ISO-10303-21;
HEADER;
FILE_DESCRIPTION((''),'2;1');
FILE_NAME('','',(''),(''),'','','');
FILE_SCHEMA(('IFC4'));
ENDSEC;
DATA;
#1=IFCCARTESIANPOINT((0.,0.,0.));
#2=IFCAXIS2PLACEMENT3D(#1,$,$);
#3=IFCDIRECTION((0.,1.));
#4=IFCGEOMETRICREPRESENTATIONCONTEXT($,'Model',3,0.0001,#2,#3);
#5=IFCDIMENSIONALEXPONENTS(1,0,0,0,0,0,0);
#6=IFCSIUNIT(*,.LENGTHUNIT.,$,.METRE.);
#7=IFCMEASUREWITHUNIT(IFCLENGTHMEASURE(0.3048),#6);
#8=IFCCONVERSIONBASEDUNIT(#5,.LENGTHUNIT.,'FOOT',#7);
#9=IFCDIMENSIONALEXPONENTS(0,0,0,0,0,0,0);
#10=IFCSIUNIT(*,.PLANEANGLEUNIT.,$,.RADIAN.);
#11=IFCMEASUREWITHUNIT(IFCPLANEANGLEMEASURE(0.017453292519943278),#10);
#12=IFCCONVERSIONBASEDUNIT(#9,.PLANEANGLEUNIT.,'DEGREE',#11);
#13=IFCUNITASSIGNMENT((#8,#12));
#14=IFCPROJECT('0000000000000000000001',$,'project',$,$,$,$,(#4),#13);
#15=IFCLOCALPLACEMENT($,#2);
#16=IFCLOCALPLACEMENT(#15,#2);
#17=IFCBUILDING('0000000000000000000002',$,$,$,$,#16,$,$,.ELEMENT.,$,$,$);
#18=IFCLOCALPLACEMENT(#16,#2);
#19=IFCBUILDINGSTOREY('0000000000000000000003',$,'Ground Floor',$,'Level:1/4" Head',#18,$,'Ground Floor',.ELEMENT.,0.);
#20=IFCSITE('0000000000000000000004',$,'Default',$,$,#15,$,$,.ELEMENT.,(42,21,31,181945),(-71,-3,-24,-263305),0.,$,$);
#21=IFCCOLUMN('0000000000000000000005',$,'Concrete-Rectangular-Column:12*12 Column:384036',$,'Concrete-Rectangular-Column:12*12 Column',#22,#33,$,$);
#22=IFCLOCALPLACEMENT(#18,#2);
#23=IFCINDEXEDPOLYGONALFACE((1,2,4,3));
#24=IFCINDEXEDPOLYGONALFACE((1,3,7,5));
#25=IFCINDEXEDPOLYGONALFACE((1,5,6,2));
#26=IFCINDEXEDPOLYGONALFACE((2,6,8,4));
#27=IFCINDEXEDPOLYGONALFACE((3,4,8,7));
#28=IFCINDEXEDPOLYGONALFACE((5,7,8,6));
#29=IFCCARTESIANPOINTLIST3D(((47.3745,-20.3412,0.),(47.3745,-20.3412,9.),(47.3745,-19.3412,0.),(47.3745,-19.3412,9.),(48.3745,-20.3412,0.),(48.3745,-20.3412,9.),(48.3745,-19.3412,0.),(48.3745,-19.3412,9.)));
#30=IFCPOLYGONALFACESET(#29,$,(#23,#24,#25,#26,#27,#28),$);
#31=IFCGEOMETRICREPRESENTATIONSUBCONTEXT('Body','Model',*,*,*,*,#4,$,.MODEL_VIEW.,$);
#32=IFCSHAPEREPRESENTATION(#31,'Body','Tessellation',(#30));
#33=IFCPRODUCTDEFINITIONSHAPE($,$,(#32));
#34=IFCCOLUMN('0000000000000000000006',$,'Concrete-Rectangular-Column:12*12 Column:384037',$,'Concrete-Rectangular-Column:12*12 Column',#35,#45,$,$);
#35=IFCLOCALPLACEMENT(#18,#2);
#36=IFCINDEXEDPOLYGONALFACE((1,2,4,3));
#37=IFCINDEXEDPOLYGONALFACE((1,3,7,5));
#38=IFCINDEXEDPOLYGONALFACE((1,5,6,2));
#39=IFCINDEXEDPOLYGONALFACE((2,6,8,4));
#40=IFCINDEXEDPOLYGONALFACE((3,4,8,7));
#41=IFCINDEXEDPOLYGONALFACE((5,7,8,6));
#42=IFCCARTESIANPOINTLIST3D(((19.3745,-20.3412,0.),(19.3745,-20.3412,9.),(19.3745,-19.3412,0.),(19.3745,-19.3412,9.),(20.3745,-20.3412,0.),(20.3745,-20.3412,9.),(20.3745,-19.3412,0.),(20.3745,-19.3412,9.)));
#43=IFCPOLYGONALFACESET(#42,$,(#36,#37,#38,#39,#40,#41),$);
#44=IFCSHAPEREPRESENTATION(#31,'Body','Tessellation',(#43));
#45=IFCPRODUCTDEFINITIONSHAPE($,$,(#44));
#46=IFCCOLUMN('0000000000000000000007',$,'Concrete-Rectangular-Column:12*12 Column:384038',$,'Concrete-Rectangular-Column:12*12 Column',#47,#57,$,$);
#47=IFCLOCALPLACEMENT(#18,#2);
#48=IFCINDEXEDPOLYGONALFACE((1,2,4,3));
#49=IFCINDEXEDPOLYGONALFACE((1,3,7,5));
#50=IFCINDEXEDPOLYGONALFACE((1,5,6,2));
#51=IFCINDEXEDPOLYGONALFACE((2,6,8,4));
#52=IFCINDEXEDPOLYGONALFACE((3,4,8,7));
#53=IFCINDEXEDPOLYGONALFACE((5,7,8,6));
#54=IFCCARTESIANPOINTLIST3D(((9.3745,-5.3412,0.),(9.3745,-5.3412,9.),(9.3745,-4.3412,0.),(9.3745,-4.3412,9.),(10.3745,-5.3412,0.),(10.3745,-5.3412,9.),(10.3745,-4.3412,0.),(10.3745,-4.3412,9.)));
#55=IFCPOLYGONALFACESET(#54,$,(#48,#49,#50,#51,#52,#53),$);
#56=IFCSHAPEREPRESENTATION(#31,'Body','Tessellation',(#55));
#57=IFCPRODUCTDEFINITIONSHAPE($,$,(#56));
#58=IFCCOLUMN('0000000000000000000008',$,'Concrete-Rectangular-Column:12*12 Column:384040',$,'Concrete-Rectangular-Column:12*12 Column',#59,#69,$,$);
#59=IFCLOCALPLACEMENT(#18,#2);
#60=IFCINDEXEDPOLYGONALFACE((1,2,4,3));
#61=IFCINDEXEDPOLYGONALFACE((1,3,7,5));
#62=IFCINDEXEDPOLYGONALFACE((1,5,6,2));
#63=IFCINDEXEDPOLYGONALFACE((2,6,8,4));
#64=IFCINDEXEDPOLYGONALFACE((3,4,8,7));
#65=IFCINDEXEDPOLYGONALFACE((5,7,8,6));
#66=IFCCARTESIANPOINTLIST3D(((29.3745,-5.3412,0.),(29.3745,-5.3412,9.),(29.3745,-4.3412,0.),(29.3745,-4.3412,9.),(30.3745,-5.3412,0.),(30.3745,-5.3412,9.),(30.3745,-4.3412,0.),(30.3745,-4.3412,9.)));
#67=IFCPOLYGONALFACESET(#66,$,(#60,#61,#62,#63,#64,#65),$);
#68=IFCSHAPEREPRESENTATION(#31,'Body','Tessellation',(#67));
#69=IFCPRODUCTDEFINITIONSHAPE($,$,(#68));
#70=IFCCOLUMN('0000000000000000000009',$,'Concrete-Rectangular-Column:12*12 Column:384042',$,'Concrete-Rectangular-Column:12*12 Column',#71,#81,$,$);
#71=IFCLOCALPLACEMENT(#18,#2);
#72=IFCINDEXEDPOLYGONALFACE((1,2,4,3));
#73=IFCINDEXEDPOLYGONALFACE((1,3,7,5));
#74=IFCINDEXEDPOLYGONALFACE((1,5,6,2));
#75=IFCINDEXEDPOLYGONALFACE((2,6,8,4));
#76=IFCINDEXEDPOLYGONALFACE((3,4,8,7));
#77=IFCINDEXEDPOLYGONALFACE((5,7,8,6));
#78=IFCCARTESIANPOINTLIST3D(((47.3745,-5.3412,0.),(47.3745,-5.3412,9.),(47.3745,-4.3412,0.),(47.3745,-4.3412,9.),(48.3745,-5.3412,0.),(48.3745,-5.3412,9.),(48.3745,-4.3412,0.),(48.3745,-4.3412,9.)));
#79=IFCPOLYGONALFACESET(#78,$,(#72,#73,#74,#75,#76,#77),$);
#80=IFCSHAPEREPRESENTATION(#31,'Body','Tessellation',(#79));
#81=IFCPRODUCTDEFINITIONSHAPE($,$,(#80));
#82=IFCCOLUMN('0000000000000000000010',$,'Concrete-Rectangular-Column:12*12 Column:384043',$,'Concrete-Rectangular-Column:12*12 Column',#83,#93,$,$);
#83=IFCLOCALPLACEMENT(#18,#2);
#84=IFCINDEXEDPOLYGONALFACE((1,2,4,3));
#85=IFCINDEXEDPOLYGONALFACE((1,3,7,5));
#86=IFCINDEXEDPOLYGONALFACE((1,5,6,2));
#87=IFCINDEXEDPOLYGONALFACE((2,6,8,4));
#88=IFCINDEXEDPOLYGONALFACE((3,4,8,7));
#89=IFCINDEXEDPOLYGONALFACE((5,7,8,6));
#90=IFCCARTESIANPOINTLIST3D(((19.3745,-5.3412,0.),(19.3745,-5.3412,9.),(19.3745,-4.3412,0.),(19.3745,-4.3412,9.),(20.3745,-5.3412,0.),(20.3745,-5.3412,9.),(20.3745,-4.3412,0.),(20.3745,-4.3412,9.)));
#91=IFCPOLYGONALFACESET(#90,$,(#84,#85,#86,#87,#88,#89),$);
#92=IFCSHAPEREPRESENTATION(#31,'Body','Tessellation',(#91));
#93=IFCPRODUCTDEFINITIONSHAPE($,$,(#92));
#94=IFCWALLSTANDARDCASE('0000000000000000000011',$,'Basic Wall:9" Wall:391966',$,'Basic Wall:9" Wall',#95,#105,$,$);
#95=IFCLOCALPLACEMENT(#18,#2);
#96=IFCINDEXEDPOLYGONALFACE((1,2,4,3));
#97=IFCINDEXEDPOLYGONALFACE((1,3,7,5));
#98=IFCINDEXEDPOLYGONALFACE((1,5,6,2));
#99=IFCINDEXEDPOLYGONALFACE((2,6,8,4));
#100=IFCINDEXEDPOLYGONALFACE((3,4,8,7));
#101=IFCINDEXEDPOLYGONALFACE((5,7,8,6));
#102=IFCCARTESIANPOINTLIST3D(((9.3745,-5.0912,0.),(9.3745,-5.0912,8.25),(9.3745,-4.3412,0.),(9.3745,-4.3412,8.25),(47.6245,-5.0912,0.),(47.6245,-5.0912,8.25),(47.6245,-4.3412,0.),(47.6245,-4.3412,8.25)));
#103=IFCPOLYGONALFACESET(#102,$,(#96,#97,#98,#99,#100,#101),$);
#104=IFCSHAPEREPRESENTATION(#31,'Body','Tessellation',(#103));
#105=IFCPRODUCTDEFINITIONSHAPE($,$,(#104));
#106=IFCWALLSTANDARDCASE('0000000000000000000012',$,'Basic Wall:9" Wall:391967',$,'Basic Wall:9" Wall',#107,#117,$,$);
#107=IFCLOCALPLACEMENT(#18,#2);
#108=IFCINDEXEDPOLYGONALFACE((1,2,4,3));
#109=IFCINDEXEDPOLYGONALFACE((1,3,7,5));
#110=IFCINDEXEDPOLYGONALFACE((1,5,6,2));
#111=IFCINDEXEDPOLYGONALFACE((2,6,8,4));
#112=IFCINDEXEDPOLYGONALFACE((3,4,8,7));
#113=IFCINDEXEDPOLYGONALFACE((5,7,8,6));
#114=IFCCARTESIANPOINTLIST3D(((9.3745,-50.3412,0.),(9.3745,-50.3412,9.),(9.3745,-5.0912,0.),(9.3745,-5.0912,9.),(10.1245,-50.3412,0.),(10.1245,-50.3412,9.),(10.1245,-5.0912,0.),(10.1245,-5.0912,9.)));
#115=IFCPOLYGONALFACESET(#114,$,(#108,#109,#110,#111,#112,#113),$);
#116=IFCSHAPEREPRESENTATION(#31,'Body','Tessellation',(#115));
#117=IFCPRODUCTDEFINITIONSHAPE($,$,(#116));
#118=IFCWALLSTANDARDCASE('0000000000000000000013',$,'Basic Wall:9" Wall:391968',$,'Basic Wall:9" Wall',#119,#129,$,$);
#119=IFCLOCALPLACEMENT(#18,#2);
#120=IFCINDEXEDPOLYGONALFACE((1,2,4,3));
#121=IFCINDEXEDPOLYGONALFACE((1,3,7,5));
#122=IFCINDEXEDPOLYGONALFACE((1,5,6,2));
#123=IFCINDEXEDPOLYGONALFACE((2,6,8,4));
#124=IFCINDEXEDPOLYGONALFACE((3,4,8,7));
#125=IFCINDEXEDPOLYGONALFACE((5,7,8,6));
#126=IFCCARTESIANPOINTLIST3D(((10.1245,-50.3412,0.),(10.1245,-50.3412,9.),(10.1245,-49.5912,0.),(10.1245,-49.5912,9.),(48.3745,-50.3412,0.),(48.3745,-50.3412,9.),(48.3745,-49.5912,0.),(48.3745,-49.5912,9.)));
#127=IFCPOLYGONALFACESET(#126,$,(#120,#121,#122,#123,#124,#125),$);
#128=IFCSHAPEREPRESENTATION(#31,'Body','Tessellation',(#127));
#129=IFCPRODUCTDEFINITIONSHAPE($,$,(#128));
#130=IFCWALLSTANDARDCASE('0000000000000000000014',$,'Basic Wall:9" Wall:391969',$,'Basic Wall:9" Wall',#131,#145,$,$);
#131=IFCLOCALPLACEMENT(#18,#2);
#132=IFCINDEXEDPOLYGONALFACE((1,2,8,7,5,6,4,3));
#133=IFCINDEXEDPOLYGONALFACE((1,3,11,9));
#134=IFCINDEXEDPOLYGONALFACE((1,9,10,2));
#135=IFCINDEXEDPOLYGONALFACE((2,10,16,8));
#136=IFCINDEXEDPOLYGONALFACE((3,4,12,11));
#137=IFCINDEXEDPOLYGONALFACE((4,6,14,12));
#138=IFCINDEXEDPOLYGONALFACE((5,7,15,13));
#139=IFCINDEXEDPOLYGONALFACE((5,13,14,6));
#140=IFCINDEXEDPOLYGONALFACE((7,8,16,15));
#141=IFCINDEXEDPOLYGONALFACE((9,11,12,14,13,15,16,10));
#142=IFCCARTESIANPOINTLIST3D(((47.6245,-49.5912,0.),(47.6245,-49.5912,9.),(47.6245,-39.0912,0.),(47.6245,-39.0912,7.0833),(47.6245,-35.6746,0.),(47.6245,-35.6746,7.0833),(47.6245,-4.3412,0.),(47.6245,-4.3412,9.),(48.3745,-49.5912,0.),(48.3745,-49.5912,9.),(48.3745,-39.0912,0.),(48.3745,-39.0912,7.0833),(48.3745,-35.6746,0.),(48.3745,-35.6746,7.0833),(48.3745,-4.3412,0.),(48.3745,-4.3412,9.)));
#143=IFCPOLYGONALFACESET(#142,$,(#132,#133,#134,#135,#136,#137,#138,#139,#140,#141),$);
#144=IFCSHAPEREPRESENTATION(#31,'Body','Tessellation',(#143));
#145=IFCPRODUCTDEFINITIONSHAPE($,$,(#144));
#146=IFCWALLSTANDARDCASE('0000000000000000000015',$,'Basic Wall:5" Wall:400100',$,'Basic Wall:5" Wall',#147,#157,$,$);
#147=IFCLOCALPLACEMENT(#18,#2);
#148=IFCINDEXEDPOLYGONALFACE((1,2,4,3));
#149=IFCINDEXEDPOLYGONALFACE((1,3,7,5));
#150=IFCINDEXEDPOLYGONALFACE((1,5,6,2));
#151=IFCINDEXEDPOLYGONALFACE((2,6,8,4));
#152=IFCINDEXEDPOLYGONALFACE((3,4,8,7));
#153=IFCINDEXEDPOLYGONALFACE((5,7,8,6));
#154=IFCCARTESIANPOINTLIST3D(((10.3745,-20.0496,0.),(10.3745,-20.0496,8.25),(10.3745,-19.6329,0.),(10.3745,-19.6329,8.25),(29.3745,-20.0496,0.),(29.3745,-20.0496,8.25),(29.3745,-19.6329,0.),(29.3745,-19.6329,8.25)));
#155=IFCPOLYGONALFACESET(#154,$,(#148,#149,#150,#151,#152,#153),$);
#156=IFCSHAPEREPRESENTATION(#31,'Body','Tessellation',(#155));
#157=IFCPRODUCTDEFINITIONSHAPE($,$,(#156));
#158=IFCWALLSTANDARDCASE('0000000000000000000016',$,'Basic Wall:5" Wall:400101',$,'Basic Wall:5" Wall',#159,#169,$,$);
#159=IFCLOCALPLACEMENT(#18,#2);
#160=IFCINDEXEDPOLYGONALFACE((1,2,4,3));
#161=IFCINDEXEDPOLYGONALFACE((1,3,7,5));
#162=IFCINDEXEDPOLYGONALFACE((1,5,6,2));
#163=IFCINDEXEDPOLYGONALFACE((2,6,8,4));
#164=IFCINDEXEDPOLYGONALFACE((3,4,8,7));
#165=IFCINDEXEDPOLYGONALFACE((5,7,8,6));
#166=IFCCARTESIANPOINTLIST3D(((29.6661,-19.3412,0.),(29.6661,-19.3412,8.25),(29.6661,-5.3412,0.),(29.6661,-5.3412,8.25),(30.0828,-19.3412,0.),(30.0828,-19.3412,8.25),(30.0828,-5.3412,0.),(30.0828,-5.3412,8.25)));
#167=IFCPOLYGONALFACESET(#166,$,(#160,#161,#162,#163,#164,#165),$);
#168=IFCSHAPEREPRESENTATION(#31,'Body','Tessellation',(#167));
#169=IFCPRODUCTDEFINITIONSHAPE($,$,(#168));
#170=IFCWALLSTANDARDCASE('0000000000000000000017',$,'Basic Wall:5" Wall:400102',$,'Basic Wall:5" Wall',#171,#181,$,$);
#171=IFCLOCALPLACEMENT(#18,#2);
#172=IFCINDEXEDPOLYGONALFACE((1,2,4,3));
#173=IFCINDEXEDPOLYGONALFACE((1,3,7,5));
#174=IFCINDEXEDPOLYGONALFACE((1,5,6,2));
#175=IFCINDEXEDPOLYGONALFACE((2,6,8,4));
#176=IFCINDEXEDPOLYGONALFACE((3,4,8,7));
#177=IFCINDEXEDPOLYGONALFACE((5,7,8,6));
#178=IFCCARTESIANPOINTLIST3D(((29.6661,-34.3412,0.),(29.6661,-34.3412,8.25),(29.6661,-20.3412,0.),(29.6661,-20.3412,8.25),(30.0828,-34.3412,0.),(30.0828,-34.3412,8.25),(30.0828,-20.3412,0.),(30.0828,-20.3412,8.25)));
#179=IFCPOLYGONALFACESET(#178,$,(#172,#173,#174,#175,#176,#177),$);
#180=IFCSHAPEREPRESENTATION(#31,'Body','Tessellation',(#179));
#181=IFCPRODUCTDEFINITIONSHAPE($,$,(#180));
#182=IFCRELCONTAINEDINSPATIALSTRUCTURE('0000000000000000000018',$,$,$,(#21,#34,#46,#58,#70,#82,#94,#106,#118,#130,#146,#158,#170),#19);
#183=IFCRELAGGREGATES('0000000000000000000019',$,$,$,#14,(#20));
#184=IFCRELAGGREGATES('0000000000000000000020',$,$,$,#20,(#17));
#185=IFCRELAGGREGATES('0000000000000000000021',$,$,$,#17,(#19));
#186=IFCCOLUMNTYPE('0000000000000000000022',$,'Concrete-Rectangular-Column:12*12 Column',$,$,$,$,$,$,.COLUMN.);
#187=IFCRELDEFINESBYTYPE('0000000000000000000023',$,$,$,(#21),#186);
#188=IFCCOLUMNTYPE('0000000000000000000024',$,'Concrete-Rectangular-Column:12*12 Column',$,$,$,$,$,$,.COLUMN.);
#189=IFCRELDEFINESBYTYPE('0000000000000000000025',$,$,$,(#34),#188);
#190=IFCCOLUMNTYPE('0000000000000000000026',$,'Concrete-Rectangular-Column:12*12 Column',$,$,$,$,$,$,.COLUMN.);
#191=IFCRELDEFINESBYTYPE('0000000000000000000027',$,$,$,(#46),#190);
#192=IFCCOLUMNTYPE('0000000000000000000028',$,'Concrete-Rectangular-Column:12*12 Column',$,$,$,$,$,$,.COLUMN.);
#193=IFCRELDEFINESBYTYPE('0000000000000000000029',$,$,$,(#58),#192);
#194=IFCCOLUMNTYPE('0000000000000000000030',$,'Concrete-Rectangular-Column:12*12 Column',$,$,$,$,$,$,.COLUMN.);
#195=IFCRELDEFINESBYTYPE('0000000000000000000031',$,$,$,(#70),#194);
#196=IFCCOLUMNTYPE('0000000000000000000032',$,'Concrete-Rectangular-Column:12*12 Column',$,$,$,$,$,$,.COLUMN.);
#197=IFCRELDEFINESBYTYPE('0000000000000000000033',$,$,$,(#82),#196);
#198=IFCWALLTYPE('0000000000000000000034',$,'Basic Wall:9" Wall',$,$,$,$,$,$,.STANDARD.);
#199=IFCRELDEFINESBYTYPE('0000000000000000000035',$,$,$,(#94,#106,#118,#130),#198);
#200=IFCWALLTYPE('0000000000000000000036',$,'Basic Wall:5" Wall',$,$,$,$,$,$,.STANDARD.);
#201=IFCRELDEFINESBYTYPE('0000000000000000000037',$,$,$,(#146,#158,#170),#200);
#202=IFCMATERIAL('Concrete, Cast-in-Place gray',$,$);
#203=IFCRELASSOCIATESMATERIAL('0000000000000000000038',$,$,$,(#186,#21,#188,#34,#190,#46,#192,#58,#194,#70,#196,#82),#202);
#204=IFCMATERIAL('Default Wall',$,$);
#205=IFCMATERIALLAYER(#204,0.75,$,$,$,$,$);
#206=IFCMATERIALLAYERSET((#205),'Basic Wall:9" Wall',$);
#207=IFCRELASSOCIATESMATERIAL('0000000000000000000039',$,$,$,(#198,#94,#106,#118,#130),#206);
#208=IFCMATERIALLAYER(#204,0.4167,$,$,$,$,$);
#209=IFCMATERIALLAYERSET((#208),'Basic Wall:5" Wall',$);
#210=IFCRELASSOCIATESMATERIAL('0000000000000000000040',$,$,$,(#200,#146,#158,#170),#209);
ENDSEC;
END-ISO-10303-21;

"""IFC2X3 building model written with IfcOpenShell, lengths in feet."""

from ifc_helpers import new_model, entity, si_unit, converted_unit, direction, frame, frame_2d, origin, origin_2d_with_axis, place, context, subcontext, project, spatial, rectangle, extrude, source, transform, mapped, material, layer, layer_set, layer_usage, type_object, type_shapes, element, save


model = new_model("IFC2X3")

# Units and contexts
model_context = context("Model", 3, precision=0.0001, world=origin(), true_north=direction((0.0, 1.0)))
body_context = subcontext(model_context, "Body", "Model", "MODEL_VIEW")
ifc_project = project(units=[converted_unit("LENGTHUNIT", "FOOT", entity("IfcLengthMeasure", 0.3048), si_unit("LENGTHUNIT", "METRE"), dimensions=[1, 0, 0, 0, 0, 0, 0]), converted_unit("PLANEANGLEUNIT", "DEGREE", entity("IfcPlaneAngleMeasure", 0.017453292519943278), si_unit("PLANEANGLEUNIT", "RADIAN"), dimensions=[0, 0, 0, 0, 0, 0, 0])], contexts=[model_context])

# Site, building, storey
site_placement = place(None, origin())
site = spatial("IfcSite", under=ifc_project, at=site_placement, Name="Default", CompositionType="ELEMENT", RefLatitude=(42, 21, 31, 181945), RefLongitude=(-71, -3, -24, -263305), RefElevation=0.0)
building_placement = place(site_placement, origin())
building = spatial("IfcBuilding", under=site, at=building_placement, CompositionType="ELEMENT")
storey_placement = place(building_placement, origin())
storey = spatial("IfcBuildingStorey", under=building, at=storey_placement, Name="Ground Floor", ObjectType="Level:1/4\" Head", LongName="Ground Floor", CompositionType="ELEMENT", Elevation=0.0)

# Columns
ifc_material_1 = material(Name="Concrete, Cast-in-Place gray")
column_type_1 = type_object("IfcColumnType", Name="Concrete-Rectangular-Column:12*12 Column", PredefinedType="COLUMN", material=ifc_material_1)
shared_shape_1 = source(origin(), body_context, "Body", "SweptSolid", [
    extrude(rectangle(XDim=1.0, YDim=1.0, at=frame_2d((0.0, 0.0), x_axis=(1.0, 0.0))), frame((47.8745, -19.8412, 0.0), z_axis=(0.0, 0.0, 1.0), x_axis=(-1.0, 0.0, 0.0)), (0.0, 0.0, 1.0), 9.0),
])
type_shapes(column_type_1, [shared_shape_1])
column_1_placement = place(storey_placement, origin())
element("IfcColumn", 1, at=column_1_placement, inside=storey, type_object=column_type_1, material=ifc_material_1, Name="Concrete-Rectangular-Column:12*12 Column:384036", ObjectType="Concrete-Rectangular-Column:12*12 Column", context=body_context, shape_type="MappedRepresentation", body=[
    mapped(shared_shape_1, transform((0.0, 0.0, 0.0), scale=1.0)),
])
column_type_2 = type_object("IfcColumnType", Name="Concrete-Rectangular-Column:12*12 Column", PredefinedType="COLUMN", material=ifc_material_1)
shared_shape_2 = source(origin(), body_context, "Body", "SweptSolid", [
    extrude(rectangle(XDim=1.0, YDim=1.0, at=frame_2d((0.0, 0.0), x_axis=(1.0, 0.0))), frame((19.8745, -19.8412, 0.0), z_axis=(0.0, 0.0, 1.0), x_axis=(-1.0, 0.0, 0.0)), (0.0, 0.0, 1.0), 9.0),
])
type_shapes(column_type_2, [shared_shape_2])
column_2_placement = place(storey_placement, origin())
element("IfcColumn", 2, at=column_2_placement, inside=storey, type_object=column_type_2, material=ifc_material_1, Name="Concrete-Rectangular-Column:12*12 Column:384037", ObjectType="Concrete-Rectangular-Column:12*12 Column", context=body_context, shape_type="MappedRepresentation", body=[
    mapped(shared_shape_2, transform((0.0, 0.0, 0.0), scale=1.0)),
])
column_type_3 = type_object("IfcColumnType", Name="Concrete-Rectangular-Column:12*12 Column", PredefinedType="COLUMN", material=ifc_material_1)
shared_shape_3 = source(origin(), body_context, "Body", "SweptSolid", [
    extrude(rectangle(XDim=1.0, YDim=1.0, at=origin_2d_with_axis()), frame((9.8745, -4.8412, 0.0), z_axis=(0.0, 0.0, 1.0), x_axis=(-1.0, 0.0, 0.0)), (0.0, 0.0, 1.0), 9.0),
])
type_shapes(column_type_3, [shared_shape_3])
column_3_placement = place(storey_placement, origin())
element("IfcColumn", 3, at=column_3_placement, inside=storey, type_object=column_type_3, material=ifc_material_1, Name="Concrete-Rectangular-Column:12*12 Column:384038", ObjectType="Concrete-Rectangular-Column:12*12 Column", context=body_context, shape_type="MappedRepresentation", body=[
    mapped(shared_shape_3, transform((0.0, 0.0, 0.0), scale=1.0)),
])
column_type_4 = type_object("IfcColumnType", Name="Concrete-Rectangular-Column:12*12 Column", PredefinedType="COLUMN", material=ifc_material_1)
shared_shape_4 = source(origin(), body_context, "Body", "SweptSolid", [
    extrude(rectangle(XDim=1.0, YDim=1.0, at=frame_2d((0.0, 0.0), x_axis=(1.0, 0.0))), frame((29.8745, -4.8412, 0.0), z_axis=(0.0, 0.0, 1.0), x_axis=(-1.0, 0.0, 0.0)), (0.0, 0.0, 1.0), 9.0),
])
type_shapes(column_type_4, [shared_shape_4])
column_4_placement = place(storey_placement, origin())
element("IfcColumn", 4, at=column_4_placement, inside=storey, type_object=column_type_4, material=ifc_material_1, Name="Concrete-Rectangular-Column:12*12 Column:384040", ObjectType="Concrete-Rectangular-Column:12*12 Column", context=body_context, shape_type="MappedRepresentation", body=[
    mapped(shared_shape_4, transform((0.0, 0.0, 0.0), scale=1.0)),
])
column_type_5 = type_object("IfcColumnType", Name="Concrete-Rectangular-Column:12*12 Column", PredefinedType="COLUMN", material=ifc_material_1)
shared_shape_5 = source(origin(), body_context, "Body", "SweptSolid", [
    extrude(rectangle(XDim=1.0, YDim=1.0, at=frame_2d((0.0, 0.0), x_axis=(1.0, 0.0))), frame((47.8745, -4.8412, 0.0), z_axis=(0.0, 0.0, 1.0), x_axis=(-1.0, 0.0, 0.0)), (0.0, 0.0, 1.0), 9.0),
])
type_shapes(column_type_5, [shared_shape_5])
column_5_placement = place(storey_placement, origin())
element("IfcColumn", 5, at=column_5_placement, inside=storey, type_object=column_type_5, material=ifc_material_1, Name="Concrete-Rectangular-Column:12*12 Column:384042", ObjectType="Concrete-Rectangular-Column:12*12 Column", context=body_context, shape_type="MappedRepresentation", body=[
    mapped(shared_shape_5, transform((0.0, 0.0, 0.0), scale=1.0)),
])
column_type_6 = type_object("IfcColumnType", Name="Concrete-Rectangular-Column:12*12 Column", PredefinedType="COLUMN", material=ifc_material_1)
shared_shape_6 = source(origin(), body_context, "Body", "SweptSolid", [
    extrude(rectangle(XDim=1.0, YDim=1.0, at=frame_2d((0.0, 0.0), x_axis=(1.0, 0.0))), frame((19.8745, -4.8412, 0.0), z_axis=(0.0, 0.0, 1.0), x_axis=(-1.0, 0.0, 0.0)), (0.0, 0.0, 1.0), 9.0),
])
type_shapes(column_type_6, [shared_shape_6])
column_6_placement = place(storey_placement, origin())
element("IfcColumn", 6, at=column_6_placement, inside=storey, type_object=column_type_6, material=ifc_material_1, Name="Concrete-Rectangular-Column:12*12 Column:384043", ObjectType="Concrete-Rectangular-Column:12*12 Column", context=body_context, shape_type="MappedRepresentation", body=[
    mapped(shared_shape_6, transform((0.0, 0.0, 0.0), scale=1.0)),
])

# Walls
ifc_material_2 = material(Name="Default Wall")
ifc_layer_1 = layer(ifc_material_2, 0.75)
ifc_layer_set_1 = layer_set([ifc_layer_1], Name="Basic Wall:9\" Wall")
ifc_layer_usage_1 = layer_usage(ifc_layer_set_1, "AXIS2", "NEGATIVE", 0.375)
wall_type_1 = type_object("IfcWallType", Name="Basic Wall:9\" Wall", PredefinedType="STANDARD", material=ifc_layer_set_1)
wall_1_placement = place(storey_placement, frame((9.3745, -4.7162, 0.0)))
element("IfcWallStandardCase", 7, at=wall_1_placement, inside=storey, type_object=wall_type_1, material=ifc_layer_usage_1, Name="Basic Wall:9\" Wall:391966", ObjectType="Basic Wall:9\" Wall", context=body_context, shape_type="SweptSolid", body=[
    extrude(rectangle(XDim=38.25, YDim=0.75, at=frame_2d((19.125, 0.0), x_axis=(-1.0, 0.0))), origin(), (0.0, 0.0, 1.0), 8.25),
])
wall_2_placement = place(storey_placement, frame((9.7495, -50.3412, 0.0), z_axis=(0.0, 0.0, 1.0), x_axis=(0.0, 1.0, 0.0)))
element("IfcWallStandardCase", 8, at=wall_2_placement, inside=storey, type_object=wall_type_1, material=ifc_layer_usage_1, Name="Basic Wall:9\" Wall:391967", ObjectType="Basic Wall:9\" Wall", context=body_context, shape_type="SweptSolid", body=[
    extrude(rectangle(XDim=45.25, YDim=0.75, at=frame_2d((22.625, 0.0), x_axis=(-1.0, 0.0))), origin(), (0.0, 0.0, 1.0), 9.0),
])
wall_3_placement = place(storey_placement, frame((48.3745, -49.9662, 0.0), z_axis=(0.0, 0.0, 1.0), x_axis=(-1.0, 0.0, 0.0)))
element("IfcWallStandardCase", 9, at=wall_3_placement, inside=storey, type_object=wall_type_1, material=ifc_layer_usage_1, Name="Basic Wall:9\" Wall:391968", ObjectType="Basic Wall:9\" Wall", context=body_context, shape_type="SweptSolid", body=[
    extrude(rectangle(XDim=38.25, YDim=0.75, at=frame_2d((19.125, 0.0), x_axis=(-1.0, 0.0))), origin(), (0.0, 0.0, 1.0), 9.0),
])

# Wall, opening
wall_4_placement = place(storey_placement, frame((47.9995, -4.3412, 0.0), z_axis=(0.0, 0.0, 1.0), x_axis=(0.0, -1.0, 0.0)))
wall_4 = element("IfcWallStandardCase", 10, at=wall_4_placement, inside=storey, type_object=wall_type_1, material=ifc_layer_usage_1, Name="Basic Wall:9\" Wall:391969", ObjectType="Basic Wall:9\" Wall", context=body_context, shape_type="SweptSolid", body=[
    extrude(rectangle(XDim=45.25, YDim=0.75, at=frame_2d((22.625, 0.0), x_axis=(1.0, 0.0))), origin(), (0.0, 0.0, 1.0), 9.0),
])
opening_1_placement = place(wall_4_placement, frame((34.75, 0.375, 0.0)))
element("IfcOpeningElement", 11, at=opening_1_placement, cuts=wall_4, ObjectType="Opening", context=body_context, shape_type="SweptSolid", body=[
    extrude(rectangle(XDim=7.0833, YDim=3.4167, at=frame_2d((3.5417, 1.7083), x_axis=(1.0, 0.0))), frame((0.0, 0.0, 0.0), z_axis=(0.0, -1.0, 0.0), x_axis=(0.0, 0.0, 1.0)), (0.0, 0.0, 1.0), 0.75),
])

# Walls
ifc_layer_2 = layer(ifc_material_2, 0.4167)
ifc_layer_set_2 = layer_set([ifc_layer_2], Name="Basic Wall:5\" Wall")
ifc_layer_usage_2 = layer_usage(ifc_layer_set_2, "AXIS2", "NEGATIVE", 0.2083)
wall_type_2 = type_object("IfcWallType", Name="Basic Wall:5\" Wall", PredefinedType="STANDARD", material=ifc_layer_set_2)
wall_5_placement = place(storey_placement, frame((10.3745, -19.8412, 0.0)))
element("IfcWallStandardCase", 12, at=wall_5_placement, inside=storey, type_object=wall_type_2, material=ifc_layer_usage_2, Name="Basic Wall:5\" Wall:400100", ObjectType="Basic Wall:5\" Wall", context=body_context, shape_type="SweptSolid", body=[
    extrude(rectangle(XDim=19.0, YDim=0.4167, at=frame_2d((9.5, 0.0), x_axis=(-1.0, 0.0))), origin(), (0.0, 0.0, 1.0), 8.25),
])
wall_6_placement = place(storey_placement, frame((29.8745, -19.3412, 0.0), z_axis=(0.0, 0.0, 1.0), x_axis=(0.0, 1.0, 0.0)))
element("IfcWallStandardCase", 13, at=wall_6_placement, inside=storey, type_object=wall_type_2, material=ifc_layer_usage_2, Name="Basic Wall:5\" Wall:400101", ObjectType="Basic Wall:5\" Wall", context=body_context, shape_type="SweptSolid", body=[
    extrude(rectangle(XDim=14.0, YDim=0.4167, at=frame_2d((7.0, 0.0), x_axis=(-1.0, 0.0))), origin(), (0.0, 0.0, 1.0), 8.25),
])
wall_7_placement = place(storey_placement, frame((29.8745, -20.3412, 0.0), z_axis=(0.0, 0.0, 1.0), x_axis=(0.0, -1.0, 0.0)))
element("IfcWallStandardCase", 14, at=wall_7_placement, inside=storey, type_object=wall_type_2, material=ifc_layer_usage_2, Name="Basic Wall:5\" Wall:400102", ObjectType="Basic Wall:5\" Wall", context=body_context, shape_type="SweptSolid", body=[
    extrude(rectangle(XDim=14.0, YDim=0.4167, at=frame_2d((7.0, 0.0), x_axis=(-1.0, 0.0))), origin(), (0.0, 0.0, 1.0), 8.25),
])

save(model, "model.ifc")
